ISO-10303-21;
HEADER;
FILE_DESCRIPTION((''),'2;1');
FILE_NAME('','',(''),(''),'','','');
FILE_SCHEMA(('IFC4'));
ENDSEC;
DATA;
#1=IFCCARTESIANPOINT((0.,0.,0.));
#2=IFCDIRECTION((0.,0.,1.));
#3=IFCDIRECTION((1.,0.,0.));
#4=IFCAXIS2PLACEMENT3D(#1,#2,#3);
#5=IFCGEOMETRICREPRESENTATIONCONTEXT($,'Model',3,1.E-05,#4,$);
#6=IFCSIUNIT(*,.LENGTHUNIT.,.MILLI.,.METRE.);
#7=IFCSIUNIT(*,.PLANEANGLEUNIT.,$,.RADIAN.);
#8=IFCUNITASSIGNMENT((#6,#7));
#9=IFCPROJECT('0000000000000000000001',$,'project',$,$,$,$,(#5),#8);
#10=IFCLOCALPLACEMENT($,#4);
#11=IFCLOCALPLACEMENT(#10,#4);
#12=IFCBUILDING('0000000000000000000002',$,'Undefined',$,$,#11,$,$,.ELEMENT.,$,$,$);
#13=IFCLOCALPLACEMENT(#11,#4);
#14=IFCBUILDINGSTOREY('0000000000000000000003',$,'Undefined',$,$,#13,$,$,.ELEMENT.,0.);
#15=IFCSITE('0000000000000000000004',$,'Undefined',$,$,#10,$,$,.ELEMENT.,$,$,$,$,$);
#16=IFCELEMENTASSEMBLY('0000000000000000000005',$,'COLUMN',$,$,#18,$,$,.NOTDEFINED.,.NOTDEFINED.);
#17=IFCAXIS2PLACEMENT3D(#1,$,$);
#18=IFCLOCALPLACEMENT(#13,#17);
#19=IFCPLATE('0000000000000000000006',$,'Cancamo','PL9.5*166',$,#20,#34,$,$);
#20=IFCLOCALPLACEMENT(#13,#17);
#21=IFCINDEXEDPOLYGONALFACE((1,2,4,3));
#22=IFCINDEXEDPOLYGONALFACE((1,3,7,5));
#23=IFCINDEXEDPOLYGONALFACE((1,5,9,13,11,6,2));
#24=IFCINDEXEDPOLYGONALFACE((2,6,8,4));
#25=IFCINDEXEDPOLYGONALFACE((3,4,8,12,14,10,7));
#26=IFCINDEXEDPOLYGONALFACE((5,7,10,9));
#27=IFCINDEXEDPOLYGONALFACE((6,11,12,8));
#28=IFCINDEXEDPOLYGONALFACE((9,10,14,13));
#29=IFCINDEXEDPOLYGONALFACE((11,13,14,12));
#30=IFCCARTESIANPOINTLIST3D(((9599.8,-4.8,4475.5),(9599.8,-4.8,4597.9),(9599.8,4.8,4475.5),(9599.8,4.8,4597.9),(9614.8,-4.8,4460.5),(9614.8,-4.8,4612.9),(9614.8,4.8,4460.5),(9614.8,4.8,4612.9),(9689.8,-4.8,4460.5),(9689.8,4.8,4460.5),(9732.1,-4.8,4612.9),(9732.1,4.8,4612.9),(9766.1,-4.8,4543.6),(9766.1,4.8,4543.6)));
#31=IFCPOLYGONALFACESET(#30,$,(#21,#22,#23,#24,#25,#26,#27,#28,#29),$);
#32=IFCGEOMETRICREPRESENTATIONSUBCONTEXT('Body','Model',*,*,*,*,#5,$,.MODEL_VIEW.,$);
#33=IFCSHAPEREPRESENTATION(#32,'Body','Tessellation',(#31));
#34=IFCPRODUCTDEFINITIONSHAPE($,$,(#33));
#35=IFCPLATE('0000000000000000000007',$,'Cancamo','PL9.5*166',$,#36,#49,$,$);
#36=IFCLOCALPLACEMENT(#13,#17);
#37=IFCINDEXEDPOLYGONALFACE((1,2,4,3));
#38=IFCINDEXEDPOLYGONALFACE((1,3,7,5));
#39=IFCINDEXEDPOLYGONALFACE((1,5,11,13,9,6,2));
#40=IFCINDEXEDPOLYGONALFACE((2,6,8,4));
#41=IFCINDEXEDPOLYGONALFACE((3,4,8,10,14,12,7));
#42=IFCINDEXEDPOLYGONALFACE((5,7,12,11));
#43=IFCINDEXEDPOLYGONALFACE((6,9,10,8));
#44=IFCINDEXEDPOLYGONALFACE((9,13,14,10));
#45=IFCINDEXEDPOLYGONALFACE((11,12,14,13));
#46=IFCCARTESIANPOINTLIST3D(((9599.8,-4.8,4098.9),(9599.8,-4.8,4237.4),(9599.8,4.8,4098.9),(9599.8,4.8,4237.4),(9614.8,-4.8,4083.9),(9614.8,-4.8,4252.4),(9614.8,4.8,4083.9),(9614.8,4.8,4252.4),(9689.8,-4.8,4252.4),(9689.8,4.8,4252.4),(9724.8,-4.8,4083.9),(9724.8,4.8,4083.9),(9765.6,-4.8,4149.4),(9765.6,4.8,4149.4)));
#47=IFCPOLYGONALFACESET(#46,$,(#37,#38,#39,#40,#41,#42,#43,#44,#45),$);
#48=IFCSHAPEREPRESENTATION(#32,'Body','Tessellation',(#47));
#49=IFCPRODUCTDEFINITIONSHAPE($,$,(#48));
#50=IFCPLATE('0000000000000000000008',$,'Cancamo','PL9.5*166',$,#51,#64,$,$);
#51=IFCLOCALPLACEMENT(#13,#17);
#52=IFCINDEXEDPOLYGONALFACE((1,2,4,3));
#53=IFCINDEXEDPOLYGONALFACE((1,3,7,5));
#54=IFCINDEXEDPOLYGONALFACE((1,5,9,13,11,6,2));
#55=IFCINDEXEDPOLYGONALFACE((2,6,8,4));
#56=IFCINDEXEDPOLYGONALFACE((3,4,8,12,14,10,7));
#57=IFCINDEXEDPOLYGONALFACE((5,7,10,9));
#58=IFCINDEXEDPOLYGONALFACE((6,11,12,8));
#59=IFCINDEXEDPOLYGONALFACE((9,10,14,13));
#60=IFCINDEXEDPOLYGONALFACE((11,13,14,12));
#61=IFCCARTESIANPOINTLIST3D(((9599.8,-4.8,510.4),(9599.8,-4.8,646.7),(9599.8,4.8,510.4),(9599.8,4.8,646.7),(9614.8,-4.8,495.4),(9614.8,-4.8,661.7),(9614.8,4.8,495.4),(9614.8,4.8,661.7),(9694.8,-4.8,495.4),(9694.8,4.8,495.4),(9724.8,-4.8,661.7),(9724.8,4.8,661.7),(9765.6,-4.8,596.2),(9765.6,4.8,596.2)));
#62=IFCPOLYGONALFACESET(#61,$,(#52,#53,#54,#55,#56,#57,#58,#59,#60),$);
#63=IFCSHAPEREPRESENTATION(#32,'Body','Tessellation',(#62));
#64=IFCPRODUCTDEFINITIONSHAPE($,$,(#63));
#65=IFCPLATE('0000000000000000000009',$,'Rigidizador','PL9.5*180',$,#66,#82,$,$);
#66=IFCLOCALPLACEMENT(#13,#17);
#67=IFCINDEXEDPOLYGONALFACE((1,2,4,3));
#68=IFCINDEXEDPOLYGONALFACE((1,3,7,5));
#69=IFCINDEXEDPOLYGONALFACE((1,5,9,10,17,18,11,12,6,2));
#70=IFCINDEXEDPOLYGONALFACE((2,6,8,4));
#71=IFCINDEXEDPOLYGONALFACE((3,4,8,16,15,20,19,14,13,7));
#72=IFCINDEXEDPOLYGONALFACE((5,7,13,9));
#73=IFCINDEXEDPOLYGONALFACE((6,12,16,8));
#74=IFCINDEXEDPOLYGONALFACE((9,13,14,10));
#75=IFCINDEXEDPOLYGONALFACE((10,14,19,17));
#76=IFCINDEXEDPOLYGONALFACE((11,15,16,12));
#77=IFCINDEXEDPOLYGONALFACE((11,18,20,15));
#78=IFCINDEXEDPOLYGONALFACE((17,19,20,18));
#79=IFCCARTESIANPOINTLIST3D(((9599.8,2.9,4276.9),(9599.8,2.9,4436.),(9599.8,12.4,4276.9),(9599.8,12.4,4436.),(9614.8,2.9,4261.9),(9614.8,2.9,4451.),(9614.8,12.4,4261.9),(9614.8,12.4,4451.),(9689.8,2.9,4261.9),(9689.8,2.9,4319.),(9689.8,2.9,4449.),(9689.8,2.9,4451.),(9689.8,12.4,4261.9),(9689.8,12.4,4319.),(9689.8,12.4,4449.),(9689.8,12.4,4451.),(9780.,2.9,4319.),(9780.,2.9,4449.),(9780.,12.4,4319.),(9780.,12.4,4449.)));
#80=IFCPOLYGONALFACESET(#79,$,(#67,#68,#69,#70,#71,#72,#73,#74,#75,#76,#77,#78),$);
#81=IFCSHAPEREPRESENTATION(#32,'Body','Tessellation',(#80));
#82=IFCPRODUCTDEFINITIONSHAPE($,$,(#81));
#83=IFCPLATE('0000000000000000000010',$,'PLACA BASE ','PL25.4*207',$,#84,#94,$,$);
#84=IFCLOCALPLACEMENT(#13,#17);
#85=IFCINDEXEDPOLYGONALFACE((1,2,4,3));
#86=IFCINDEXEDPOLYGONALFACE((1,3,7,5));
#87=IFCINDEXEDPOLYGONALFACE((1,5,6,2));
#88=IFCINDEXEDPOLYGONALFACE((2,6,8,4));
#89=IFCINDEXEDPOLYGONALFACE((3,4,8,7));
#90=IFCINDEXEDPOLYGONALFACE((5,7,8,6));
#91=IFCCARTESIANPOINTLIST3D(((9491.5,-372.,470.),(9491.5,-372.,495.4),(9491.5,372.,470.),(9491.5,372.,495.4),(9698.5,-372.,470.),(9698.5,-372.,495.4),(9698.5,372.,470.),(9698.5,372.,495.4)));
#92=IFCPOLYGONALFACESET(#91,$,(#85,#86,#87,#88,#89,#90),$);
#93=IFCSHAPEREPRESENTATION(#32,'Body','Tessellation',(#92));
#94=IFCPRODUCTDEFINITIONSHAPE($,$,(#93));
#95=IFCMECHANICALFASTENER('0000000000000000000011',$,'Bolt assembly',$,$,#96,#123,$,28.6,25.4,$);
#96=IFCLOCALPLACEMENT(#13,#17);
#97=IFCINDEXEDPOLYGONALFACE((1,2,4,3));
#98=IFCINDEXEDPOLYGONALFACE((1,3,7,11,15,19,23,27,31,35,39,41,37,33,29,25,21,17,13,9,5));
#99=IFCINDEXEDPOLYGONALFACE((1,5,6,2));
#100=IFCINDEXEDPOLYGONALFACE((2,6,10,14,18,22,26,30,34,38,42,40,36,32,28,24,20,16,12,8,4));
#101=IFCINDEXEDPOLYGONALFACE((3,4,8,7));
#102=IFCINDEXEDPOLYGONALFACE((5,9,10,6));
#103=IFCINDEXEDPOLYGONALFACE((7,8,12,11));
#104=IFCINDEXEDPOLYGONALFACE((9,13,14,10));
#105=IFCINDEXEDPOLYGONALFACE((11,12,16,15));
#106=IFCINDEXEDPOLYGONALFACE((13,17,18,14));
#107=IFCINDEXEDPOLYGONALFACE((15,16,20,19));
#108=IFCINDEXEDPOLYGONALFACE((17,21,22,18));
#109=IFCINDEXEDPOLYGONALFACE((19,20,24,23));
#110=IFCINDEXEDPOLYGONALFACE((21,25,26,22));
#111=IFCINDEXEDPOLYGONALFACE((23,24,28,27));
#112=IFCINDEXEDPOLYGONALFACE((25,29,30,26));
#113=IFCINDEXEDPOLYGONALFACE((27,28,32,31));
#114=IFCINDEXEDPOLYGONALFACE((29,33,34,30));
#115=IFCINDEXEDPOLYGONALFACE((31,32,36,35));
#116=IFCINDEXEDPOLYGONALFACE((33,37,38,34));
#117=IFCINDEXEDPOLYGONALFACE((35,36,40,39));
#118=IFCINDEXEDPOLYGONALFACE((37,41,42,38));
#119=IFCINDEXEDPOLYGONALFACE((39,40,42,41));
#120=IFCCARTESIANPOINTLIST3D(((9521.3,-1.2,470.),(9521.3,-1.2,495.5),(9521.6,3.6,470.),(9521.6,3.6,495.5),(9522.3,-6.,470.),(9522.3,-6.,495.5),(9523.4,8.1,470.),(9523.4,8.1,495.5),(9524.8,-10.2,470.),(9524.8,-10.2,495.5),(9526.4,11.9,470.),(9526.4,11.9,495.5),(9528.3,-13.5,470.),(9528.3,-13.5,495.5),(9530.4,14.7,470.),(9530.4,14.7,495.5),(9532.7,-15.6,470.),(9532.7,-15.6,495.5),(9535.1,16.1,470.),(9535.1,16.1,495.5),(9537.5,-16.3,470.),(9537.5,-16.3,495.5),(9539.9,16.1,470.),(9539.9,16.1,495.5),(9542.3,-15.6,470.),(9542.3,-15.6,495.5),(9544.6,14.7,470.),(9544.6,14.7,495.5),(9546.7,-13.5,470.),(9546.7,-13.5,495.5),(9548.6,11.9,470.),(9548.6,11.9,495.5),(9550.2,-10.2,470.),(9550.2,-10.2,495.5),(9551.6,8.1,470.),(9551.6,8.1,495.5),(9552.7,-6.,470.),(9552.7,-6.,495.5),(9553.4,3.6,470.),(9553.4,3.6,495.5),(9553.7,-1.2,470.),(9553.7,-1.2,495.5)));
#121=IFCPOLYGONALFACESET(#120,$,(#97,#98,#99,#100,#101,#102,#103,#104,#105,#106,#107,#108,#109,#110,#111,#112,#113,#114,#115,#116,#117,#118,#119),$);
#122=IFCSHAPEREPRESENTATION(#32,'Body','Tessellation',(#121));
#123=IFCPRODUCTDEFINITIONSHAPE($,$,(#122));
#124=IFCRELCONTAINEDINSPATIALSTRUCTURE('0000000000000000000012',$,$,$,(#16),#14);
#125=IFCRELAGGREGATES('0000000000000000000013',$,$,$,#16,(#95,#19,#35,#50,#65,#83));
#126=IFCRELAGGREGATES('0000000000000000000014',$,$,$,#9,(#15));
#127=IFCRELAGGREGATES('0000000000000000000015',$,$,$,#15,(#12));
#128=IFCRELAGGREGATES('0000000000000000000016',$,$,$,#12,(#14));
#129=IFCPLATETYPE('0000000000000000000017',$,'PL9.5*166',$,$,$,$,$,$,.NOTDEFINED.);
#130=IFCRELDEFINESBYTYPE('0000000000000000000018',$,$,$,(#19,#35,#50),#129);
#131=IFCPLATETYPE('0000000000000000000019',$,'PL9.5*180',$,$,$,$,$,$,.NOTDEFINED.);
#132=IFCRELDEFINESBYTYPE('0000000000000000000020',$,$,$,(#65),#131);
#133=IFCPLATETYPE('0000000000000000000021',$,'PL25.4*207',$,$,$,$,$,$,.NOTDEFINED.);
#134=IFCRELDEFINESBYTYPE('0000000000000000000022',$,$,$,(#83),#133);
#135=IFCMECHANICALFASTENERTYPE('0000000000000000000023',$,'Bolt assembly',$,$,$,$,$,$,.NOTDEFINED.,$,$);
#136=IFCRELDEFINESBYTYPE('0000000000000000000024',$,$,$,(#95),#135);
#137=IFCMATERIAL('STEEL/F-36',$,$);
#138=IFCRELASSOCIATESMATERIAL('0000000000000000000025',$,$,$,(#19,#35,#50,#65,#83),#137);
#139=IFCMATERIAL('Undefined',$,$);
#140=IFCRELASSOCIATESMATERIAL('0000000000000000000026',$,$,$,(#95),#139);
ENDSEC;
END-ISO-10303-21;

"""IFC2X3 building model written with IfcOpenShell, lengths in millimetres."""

from ifc_helpers import new_model, si_unit, frame, origin_with_axes, origin_2d_with_axis, place, context, subcontext, project, spatial, polyline, circle, outline, extrude, source, transform, mapped, material, type_object, element, aggregate, save


model = new_model("IFC2X3")

# Units and contexts
model_context = context("Model", 3, precision=1e-05, world=origin_with_axes())
body_context = subcontext(model_context, "Body", "Model", "MODEL_VIEW")
ifc_project = project(units=[si_unit("LENGTHUNIT", "METRE", prefix="MILLI"), si_unit("PLANEANGLEUNIT", "RADIAN")], contexts=[model_context])

# Site, building, storey
site_placement = place(None, origin_with_axes())
site = spatial("IfcSite", under=ifc_project, at=site_placement, Name="Undefined", CompositionType="ELEMENT")
building_placement = place(site_placement, origin_with_axes())
building = spatial("IfcBuilding", under=site, at=building_placement, Name="Undefined", CompositionType="ELEMENT")
storey_placement = place(building_placement, origin_with_axes())
storey = spatial("IfcBuildingStorey", under=building, at=storey_placement, Name="Undefined", CompositionType="ELEMENT", Elevation=0.0)

# Element assembly
assembly_1_placement = place(storey_placement, origin_with_axes())
assembly_1 = element("IfcElementAssembly", 1, at=assembly_1_placement, inside=storey, Name="COLUMN", AssemblyPlace="NOTDEFINED", PredefinedType="NOTDEFINED")
ifc_material_1 = material(Name="STEEL/F-36")

# Plates
plate_type_1 = type_object("IfcPlateType", Name="PL9.5*166", PredefinedType="NOTDEFINED")
plate_1_placement = place(assembly_1_placement, frame((9599.8, 0.0, 4460.5), z_axis=(0.0, 1.0, 0.0), x_axis=(0.0, 0.0, 1.0)))
plate_1 = element("IfcPlate", 2, at=plate_1_placement, type_object=plate_type_1, material=ifc_material_1, Name="Cancamo", Description="PL9.5*166", context=body_context, shape_type="SweptSolid", body=[
    extrude(outline(polyline([(0.0, 15.0), (15.0, 0.0), (137.4, 0.0), (152.4, 15.0), (152.4, 132.4), (83.0, 166.3), (0.0, 90.0), (0.0, 15.0)])), frame((0.0, 0.0, -4.8), z_axis=(0.0, 0.0, 1.0), x_axis=(1.0, 0.0, 0.0)), (0.0, 0.0, 1.0), 9.5),
])
plate_2_placement = place(assembly_1_placement, frame((9599.8, 0.0, 4083.9), z_axis=(0.0, 1.0, 0.0), x_axis=(0.0, 0.0, 1.0)))
plate_2 = element("IfcPlate", 3, at=plate_2_placement, type_object=plate_type_1, material=ifc_material_1, Name="Cancamo", Description="PL9.5*166", context=body_context, shape_type="SweptSolid", body=[
    extrude(outline(polyline([(0.0, 15.0), (15.0, 0.0), (153.5, 0.0), (168.5, 15.0), (168.5, 90.0), (65.5, 165.9), (0.0, 125.1), (0.0, 15.0)])), frame((0.0, 0.0, -4.8), z_axis=(0.0, 0.0, 1.0), x_axis=(1.0, 0.0, 0.0)), (0.0, 0.0, 1.0), 9.5),
])
plate_3_placement = place(assembly_1_placement, frame((9599.8, 0.0, 495.4), z_axis=(0.0, 1.0, 0.0), x_axis=(0.0, 0.0, 1.0)))
plate_3 = element("IfcPlate", 4, at=plate_3_placement, type_object=plate_type_1, material=ifc_material_1, Name="Cancamo", Description="PL9.5*166", context=body_context, shape_type="SweptSolid", body=[
    extrude(outline(polyline([(0.0, 15.0), (15.0, 0.0), (151.3, 0.0), (166.3, 15.0), (166.3, 125.1), (100.8, 165.9), (0.0, 95.0), (0.0, 15.0)])), frame((0.0, 0.0, -4.8), z_axis=(0.0, 0.0, 1.0), x_axis=(1.0, 0.0, 0.0)), (0.0, 0.0, 1.0), 9.5),
])
plate_type_2 = type_object("IfcPlateType", Name="PL9.5*180", PredefinedType="NOTDEFINED")
plate_4_placement = place(assembly_1_placement, frame((9689.8, 7.7, 4451.0), z_axis=(0.0, -1.0, 0.0), x_axis=(-1.0, 0.0, -0.000004)))
plate_4 = element("IfcPlate", 5, at=plate_4_placement, type_object=plate_type_2, material=ifc_material_1, Name="Rigidizador", Description="PL9.5*180", context=body_context, shape_type="SweptSolid", body=[
    extrude(outline(polyline([(0.0, 0.0), (75.0, 0.0), (90.0, 15.0), (90.0, 174.1), (75.0, 189.1), (0.0, 189.1), (0.0, 132.0), (-90.2, 132.0), (-90.2, 2.0), (0.0, 2.0), (0.0, 0.0)])), frame((0.0, 0.0, -4.8), z_axis=(0.0, 0.0, 1.0), x_axis=(1.0, 0.0, 0.0)), (0.0, 0.0, 1.0), 9.5),
])
plate_type_3 = type_object("IfcPlateType", Name="PL25.4*207", PredefinedType="NOTDEFINED")
plate_5_placement = place(assembly_1_placement, frame((9595.0, -372.0, 482.7), z_axis=(0.0, 0.0, 1.0), x_axis=(0.0, 1.0, 0.0)))
plate_5 = element("IfcPlate", 6, at=plate_5_placement, type_object=plate_type_3, material=ifc_material_1, Name="PLACA BASE ", Description="PL25.4*207", context=body_context, shape_type="SweptSolid", body=[
    extrude(outline(polyline([(0.0, -103.5), (0.0, 103.5), (744.0, 103.5), (744.0, -103.5), (0.0, -103.5)])), frame((0.0, 0.0, -12.7), z_axis=(0.0, 0.0, 1.0), x_axis=(1.0, 0.0, 0.0)), (0.0, 0.0, 1.0), 25.4),
])

# Mechanical fastener
ifc_material_2 = material(Name="Undefined")
mechanical_fastener_type = type_object("IfcMechanicalFastenerType", Name="Bolt assembly")
shared_shape_1 = source(origin_with_axes(), body_context, "Body", "SweptSolid", [
    extrude(circle(Radius=16.3, at=origin_2d_with_axis()), frame((0.0, -25.4, 0.0), z_axis=(0.0, 1.0, 0.0), x_axis=(1.0, 0.0, 0.0)), (0.0, 0.0, 1.0), 25.5),
])
mechanical_fastener_1_placement = place(assembly_1_placement, frame((9537.5, 0.0, 495.4), z_axis=(-1.0, 0.0, 0.0), x_axis=(0.0, -1.0, 0.0)))
mechanical_fastener_1 = element("IfcMechanicalFastener", 7, at=mechanical_fastener_1_placement, type_object=mechanical_fastener_type, material=ifc_material_2, Name="Bolt assembly", NominalDiameter=28.6, NominalLength=25.4, context=body_context, shape_type="MappedRepresentation", body=[
    mapped(shared_shape_1, transform((0.0, 0.0, 0.0))),
])
aggregate(assembly_1, [mechanical_fastener_1, plate_1, plate_2, plate_3, plate_4, plate_5])

save(model, "model.ifc")
